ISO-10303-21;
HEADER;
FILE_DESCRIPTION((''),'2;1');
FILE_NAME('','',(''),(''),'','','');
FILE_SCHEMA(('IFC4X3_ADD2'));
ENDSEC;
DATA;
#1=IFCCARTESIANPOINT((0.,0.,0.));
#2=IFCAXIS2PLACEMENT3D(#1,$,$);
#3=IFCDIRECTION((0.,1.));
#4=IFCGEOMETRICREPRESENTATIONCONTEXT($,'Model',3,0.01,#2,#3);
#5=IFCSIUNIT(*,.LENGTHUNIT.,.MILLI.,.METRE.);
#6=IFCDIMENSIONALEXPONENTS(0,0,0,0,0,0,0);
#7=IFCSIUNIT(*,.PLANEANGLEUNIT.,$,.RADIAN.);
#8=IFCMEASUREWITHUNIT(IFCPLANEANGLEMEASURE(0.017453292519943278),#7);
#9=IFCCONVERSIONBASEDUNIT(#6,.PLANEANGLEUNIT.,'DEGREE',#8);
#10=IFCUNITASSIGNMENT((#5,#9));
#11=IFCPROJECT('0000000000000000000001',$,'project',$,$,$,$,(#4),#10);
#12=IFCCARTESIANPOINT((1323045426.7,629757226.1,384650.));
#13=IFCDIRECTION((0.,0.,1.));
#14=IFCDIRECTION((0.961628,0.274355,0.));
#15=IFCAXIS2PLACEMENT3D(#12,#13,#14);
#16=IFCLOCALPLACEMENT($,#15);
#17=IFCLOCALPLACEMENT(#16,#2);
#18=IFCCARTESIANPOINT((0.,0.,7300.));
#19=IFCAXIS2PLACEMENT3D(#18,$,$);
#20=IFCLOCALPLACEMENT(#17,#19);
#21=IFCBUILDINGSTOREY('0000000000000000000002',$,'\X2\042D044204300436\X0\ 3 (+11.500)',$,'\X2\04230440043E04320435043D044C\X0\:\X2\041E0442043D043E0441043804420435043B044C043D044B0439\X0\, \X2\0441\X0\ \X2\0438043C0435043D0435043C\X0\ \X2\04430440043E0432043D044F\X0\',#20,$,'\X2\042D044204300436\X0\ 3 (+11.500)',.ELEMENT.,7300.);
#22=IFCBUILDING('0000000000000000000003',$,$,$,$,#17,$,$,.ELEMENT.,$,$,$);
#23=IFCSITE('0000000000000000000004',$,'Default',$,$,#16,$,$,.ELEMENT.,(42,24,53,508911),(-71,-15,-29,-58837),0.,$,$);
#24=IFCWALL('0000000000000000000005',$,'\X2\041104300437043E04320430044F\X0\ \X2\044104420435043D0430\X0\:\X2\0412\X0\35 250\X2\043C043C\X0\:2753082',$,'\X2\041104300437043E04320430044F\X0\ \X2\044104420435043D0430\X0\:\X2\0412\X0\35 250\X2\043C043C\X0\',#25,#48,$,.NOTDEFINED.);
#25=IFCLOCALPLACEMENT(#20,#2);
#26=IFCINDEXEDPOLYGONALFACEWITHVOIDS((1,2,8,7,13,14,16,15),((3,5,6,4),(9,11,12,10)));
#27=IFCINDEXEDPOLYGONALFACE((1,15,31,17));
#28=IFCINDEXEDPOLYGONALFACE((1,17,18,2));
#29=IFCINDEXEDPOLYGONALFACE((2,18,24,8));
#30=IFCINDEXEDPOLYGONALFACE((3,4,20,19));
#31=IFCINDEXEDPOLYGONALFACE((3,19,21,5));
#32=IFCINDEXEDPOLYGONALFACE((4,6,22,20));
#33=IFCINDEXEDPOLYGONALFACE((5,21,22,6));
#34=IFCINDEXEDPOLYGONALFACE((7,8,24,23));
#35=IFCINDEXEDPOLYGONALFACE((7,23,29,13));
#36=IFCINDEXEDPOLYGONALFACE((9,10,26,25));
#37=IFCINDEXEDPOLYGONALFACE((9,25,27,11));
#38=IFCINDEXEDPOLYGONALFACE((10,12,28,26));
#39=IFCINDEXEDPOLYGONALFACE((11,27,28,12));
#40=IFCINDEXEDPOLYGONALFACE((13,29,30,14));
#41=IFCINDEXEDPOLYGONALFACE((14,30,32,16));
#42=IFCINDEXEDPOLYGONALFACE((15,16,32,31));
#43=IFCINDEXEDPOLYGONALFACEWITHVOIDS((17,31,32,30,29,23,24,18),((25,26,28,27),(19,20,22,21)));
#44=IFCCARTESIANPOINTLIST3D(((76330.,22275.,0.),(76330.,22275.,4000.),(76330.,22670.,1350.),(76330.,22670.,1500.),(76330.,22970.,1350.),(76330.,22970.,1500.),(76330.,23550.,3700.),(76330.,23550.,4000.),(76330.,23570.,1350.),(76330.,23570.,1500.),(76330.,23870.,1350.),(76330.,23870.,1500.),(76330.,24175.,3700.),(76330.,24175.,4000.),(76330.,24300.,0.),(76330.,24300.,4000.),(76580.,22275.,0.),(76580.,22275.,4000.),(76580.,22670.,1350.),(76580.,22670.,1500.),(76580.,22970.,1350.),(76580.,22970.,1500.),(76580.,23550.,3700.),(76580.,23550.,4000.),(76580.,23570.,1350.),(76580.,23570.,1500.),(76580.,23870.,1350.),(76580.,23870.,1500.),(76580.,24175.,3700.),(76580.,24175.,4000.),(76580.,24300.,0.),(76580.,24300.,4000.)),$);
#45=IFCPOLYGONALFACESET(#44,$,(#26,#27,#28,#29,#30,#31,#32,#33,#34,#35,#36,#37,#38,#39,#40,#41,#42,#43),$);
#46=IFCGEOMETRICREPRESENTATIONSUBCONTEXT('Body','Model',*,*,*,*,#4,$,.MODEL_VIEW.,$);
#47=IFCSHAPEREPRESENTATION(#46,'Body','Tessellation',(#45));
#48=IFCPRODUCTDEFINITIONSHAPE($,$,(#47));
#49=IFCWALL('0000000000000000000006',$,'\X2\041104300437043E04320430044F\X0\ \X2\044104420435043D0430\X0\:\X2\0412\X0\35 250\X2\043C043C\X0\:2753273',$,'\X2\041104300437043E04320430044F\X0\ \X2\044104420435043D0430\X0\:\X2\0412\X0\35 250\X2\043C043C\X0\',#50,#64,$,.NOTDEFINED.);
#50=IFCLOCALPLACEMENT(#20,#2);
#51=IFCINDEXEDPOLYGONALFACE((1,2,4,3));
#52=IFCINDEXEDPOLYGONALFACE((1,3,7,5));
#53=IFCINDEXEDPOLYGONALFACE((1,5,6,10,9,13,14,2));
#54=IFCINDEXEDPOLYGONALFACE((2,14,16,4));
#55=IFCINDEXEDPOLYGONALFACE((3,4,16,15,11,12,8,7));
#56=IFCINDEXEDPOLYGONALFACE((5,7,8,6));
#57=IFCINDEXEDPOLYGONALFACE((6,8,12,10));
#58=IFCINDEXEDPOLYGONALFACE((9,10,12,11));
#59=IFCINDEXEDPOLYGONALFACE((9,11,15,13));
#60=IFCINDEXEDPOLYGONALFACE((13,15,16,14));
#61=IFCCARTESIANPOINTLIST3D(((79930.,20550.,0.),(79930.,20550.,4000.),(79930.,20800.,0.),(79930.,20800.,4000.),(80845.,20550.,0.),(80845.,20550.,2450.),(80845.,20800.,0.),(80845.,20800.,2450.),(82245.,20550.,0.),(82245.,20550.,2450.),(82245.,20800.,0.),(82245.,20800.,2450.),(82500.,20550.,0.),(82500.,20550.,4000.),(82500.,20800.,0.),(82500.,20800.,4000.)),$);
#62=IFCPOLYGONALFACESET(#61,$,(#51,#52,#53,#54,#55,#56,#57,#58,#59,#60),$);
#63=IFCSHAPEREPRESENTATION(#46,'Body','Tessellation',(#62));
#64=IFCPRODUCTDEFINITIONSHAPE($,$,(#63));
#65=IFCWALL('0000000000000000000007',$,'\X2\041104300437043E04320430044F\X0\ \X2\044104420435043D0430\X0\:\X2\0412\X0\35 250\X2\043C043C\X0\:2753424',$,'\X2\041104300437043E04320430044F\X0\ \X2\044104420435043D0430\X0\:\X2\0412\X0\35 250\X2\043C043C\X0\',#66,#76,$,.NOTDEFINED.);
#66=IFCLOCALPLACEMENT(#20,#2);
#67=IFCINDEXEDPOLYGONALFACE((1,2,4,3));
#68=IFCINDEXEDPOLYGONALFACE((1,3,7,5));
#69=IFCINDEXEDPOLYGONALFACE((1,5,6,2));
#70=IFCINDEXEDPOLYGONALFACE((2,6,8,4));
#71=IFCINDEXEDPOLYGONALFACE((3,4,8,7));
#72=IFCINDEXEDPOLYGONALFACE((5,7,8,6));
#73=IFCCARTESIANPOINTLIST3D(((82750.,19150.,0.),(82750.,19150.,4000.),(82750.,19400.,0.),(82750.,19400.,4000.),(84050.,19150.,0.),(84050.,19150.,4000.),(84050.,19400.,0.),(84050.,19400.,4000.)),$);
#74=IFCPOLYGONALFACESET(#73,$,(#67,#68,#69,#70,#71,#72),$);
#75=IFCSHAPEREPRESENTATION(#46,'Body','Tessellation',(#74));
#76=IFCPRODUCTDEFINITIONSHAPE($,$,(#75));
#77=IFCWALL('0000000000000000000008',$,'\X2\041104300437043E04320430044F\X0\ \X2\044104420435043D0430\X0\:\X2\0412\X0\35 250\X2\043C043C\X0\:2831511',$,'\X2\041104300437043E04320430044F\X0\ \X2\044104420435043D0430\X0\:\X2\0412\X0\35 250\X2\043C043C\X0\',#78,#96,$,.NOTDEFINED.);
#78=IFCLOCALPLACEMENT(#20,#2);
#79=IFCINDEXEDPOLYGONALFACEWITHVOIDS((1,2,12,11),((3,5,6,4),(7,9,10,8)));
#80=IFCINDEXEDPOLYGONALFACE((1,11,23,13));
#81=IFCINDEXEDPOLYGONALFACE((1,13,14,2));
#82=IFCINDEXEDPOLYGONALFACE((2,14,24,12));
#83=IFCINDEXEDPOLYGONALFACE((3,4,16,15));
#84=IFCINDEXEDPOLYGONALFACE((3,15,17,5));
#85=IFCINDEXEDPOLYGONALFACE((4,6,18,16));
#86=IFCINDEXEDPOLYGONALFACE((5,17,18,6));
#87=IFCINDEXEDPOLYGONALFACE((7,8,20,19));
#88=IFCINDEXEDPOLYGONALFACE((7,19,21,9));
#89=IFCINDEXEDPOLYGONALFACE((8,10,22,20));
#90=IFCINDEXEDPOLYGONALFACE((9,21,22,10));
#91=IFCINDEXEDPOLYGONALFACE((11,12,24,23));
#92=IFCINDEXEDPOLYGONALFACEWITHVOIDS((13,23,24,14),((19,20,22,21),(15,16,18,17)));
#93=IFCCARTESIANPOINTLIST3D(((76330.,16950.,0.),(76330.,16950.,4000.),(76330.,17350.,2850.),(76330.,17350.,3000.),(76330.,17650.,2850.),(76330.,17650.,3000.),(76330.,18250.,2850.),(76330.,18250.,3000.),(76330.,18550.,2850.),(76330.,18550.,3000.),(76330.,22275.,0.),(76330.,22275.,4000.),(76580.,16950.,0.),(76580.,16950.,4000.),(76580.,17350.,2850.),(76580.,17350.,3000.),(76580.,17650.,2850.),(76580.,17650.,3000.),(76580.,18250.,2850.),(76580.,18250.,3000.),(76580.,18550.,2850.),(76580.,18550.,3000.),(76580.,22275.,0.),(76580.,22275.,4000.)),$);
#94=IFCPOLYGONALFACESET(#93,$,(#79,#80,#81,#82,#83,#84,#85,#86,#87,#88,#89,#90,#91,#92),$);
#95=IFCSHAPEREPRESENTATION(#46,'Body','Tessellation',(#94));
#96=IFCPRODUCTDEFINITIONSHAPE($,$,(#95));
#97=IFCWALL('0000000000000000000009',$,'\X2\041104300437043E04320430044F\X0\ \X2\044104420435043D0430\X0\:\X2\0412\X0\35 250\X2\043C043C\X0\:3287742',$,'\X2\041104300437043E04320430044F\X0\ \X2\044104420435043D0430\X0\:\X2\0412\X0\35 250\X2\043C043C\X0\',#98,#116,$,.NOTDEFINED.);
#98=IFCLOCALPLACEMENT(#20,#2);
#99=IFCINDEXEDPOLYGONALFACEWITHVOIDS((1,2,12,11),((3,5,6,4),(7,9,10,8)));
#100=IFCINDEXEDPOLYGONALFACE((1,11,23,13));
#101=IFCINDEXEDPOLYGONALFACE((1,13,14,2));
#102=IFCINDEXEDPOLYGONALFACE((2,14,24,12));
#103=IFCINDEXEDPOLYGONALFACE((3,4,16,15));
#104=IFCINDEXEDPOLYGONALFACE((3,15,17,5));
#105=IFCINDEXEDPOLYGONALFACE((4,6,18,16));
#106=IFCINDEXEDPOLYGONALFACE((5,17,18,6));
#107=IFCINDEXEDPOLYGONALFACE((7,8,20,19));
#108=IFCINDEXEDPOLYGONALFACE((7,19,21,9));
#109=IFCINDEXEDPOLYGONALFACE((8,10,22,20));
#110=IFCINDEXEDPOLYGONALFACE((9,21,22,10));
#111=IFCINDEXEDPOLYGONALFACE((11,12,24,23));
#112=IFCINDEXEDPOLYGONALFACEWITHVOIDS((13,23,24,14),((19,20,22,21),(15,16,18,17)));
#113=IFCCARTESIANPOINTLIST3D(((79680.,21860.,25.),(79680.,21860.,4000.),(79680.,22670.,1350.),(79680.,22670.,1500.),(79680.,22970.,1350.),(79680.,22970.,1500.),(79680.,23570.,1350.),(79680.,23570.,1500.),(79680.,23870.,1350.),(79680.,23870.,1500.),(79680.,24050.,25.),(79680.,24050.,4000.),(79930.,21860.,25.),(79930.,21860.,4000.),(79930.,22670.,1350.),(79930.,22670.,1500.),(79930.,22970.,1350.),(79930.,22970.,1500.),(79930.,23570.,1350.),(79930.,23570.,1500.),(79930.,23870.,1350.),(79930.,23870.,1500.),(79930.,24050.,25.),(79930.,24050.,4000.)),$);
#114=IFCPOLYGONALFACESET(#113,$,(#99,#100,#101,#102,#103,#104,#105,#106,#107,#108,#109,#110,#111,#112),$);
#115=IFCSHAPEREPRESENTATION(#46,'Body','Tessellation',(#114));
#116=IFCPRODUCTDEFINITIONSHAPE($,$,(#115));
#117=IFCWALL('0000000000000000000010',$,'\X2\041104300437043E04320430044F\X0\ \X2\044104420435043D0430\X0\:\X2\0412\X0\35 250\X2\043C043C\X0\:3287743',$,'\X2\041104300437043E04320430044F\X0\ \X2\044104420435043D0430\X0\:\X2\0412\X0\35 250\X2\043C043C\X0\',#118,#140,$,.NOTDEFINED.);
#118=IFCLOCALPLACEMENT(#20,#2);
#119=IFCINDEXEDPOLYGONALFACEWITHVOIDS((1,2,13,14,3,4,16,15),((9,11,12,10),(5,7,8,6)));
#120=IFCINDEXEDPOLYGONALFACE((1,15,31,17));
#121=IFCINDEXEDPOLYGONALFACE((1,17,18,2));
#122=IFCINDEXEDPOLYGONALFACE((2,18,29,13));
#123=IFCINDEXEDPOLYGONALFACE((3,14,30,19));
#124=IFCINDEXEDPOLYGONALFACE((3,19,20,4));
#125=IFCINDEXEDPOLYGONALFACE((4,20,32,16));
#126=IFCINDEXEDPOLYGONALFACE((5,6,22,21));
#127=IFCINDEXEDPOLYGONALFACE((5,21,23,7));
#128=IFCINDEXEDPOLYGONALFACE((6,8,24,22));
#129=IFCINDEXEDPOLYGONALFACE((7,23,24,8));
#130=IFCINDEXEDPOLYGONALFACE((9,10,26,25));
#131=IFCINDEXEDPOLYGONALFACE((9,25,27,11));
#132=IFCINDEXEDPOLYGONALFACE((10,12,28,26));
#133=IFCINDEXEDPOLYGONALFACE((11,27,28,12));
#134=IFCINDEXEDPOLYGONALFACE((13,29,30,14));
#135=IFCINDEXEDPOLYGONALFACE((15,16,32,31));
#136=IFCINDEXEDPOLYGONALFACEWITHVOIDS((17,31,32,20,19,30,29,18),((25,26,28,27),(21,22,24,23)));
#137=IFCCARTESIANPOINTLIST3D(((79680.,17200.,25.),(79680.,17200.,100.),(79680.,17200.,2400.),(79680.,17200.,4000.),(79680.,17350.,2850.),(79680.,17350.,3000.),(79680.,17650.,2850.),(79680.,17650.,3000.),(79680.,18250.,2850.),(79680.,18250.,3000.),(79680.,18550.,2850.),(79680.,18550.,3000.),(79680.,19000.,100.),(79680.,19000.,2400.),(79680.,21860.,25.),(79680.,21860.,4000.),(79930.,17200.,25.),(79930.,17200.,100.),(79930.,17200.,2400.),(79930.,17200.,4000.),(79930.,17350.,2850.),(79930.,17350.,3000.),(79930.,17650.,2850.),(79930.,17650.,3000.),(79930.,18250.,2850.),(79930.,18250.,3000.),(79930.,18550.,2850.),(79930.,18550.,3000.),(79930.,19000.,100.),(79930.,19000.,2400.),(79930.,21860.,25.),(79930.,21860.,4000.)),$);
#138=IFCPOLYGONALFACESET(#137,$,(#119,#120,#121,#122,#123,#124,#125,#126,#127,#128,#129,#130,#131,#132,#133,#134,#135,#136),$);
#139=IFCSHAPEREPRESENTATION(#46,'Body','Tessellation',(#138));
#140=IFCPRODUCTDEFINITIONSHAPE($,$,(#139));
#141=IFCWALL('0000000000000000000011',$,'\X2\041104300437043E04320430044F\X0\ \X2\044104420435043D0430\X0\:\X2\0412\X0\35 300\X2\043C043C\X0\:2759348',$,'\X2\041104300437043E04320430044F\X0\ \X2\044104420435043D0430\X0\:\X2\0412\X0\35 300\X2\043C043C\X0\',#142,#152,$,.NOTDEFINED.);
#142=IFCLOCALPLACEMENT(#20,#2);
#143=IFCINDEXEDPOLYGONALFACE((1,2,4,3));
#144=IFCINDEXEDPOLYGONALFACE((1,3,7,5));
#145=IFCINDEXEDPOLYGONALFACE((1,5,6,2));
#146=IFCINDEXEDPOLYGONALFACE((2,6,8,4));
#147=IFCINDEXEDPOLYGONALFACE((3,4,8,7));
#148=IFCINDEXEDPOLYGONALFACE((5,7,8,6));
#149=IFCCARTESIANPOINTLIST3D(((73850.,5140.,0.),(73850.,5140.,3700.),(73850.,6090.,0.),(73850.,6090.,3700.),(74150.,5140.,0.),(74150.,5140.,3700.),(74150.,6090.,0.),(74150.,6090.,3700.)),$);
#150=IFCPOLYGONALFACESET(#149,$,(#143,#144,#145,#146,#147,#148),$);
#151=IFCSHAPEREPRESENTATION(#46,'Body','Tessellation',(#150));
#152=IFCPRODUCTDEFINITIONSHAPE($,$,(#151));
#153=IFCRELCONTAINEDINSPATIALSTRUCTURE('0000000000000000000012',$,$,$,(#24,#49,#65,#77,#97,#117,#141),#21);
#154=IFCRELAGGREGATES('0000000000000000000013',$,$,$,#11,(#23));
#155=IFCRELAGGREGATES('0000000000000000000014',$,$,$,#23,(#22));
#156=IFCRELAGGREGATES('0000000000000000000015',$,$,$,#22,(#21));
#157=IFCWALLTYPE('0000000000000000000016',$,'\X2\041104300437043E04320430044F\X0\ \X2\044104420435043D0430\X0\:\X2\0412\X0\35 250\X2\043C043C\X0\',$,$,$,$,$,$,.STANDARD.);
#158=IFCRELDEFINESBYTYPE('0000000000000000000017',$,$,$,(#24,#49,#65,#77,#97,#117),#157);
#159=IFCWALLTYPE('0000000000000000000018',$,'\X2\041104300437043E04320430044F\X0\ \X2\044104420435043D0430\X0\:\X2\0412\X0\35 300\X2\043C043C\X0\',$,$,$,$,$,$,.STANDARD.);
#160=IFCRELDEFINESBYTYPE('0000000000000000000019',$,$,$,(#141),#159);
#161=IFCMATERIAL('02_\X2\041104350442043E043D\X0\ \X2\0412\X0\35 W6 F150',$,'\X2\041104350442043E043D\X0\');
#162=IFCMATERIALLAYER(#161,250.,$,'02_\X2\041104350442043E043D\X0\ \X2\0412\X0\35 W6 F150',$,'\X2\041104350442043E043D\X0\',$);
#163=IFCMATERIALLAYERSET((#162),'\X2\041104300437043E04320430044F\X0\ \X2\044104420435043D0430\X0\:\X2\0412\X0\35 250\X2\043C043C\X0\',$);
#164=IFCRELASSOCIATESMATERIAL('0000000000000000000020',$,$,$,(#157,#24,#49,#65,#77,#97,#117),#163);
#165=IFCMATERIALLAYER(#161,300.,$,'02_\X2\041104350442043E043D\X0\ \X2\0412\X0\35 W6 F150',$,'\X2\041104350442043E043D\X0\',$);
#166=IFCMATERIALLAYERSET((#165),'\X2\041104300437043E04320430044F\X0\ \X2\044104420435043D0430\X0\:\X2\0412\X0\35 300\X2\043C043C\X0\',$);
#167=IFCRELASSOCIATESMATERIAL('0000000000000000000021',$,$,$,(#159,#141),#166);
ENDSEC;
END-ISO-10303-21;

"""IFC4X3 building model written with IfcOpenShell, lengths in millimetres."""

from ifc_helpers import new_model, entity, si_unit, converted_unit, direction, frame, frame_2d, origin, place, context, subcontext, project, spatial, rectangle, extrude, material, layer, layer_set, type_object, element, save


model = new_model("IFC4X3")

# Units and contexts
model_context = context("Model", 3, precision=0.01, world=origin(), true_north=direction((0.0, 1.0)))
body_context = subcontext(model_context, "Body", "Model", "MODEL_VIEW")
ifc_project = project(units=[si_unit("LENGTHUNIT", "METRE", prefix="MILLI"), converted_unit("PLANEANGLEUNIT", "DEGREE", entity("IfcPlaneAngleMeasure", 0.017453292519943278), si_unit("PLANEANGLEUNIT", "RADIAN"), dimensions=[0, 0, 0, 0, 0, 0, 0])], contexts=[model_context])

# Site, building, storey
site_placement = place(None, frame((1323045426.7, 629757226.1, 384650.0), z_axis=(0.0, 0.0, 1.0), x_axis=(0.961628, 0.274355, 0.0)))
site = spatial("IfcSite", under=ifc_project, at=site_placement, Name="Default", CompositionType="ELEMENT", RefLatitude=(42, 24, 53, 508911), RefLongitude=(-71, -15, -29, -58837), RefElevation=0.0)
building_placement = place(site_placement, origin())
building = spatial("IfcBuilding", under=site, at=building_placement, CompositionType="ELEMENT")
storey_placement = place(building_placement, frame((0.0, 0.0, 7300.0)))
storey = spatial("IfcBuildingStorey", under=building, at=storey_placement, Name="Этаж 3 (+11.500)", ObjectType="Уровень:Относительный, с именем уровня", LongName="Этаж 3 (+11.500)", CompositionType="ELEMENT", Elevation=7300.0)

# Wall, openings
ifc_material = material(Name="02_Бетон В35 W6 F150", Category="Бетон")
ifc_layer_1 = layer(ifc_material, 250.0, Name="02_Бетон В35 W6 F150", Category="Бетон")
ifc_layer_set_1 = layer_set([ifc_layer_1], Name="Базовая стена:В35 250мм")
wall_type_1 = type_object("IfcWallType", Name="Базовая стена:В35 250мм", PredefinedType="STANDARD", material=ifc_layer_set_1)
wall_1_placement = place(storey_placement, frame((76455.0, 24300.0, 0.0), z_axis=(0.0, 0.0, 1.0), x_axis=(0.0, -1.0, 0.0)))
wall_1 = element("IfcWall", 1, at=wall_1_placement, inside=storey, type_object=wall_type_1, material=ifc_layer_set_1, Name="Базовая стена:В35 250мм:2753082", ObjectType="Базовая стена:В35 250мм", PredefinedType="NOTDEFINED", context=body_context, shape_type="SweptSolid", body=[
    extrude(rectangle(XDim=2025.0, YDim=250.0, at=frame_2d((1012.5, 0.0), x_axis=(-1.0, 0.0))), origin(), (0.0, 0.0, 1.0), 4000.0),
])
opening_1_placement = place(wall_1_placement, origin())
element("IfcOpeningElement", 2, at=opening_1_placement, cuts=wall_1, PredefinedType="OPENING", context=body_context, shape_type="SweptSolid", body=[
    extrude(rectangle(XDim=300.0, YDim=625.0, at=frame_2d((0.0, 0.0), x_axis=(0.0, 1.0))), frame((437.5, 125.0, 3850.0), z_axis=(0.0, -1.0, 0.0), x_axis=(-1.0, 0.0, 0.0)), (0.0, 0.0, 1.0), 250.0),
])
opening_2_placement = place(wall_1_placement, frame((24300.0, -76455.0, 1350.0), z_axis=(0.0, 0.0, 1.0), x_axis=(0.0, 1.0, 0.0)))
element("IfcOpeningElement", 3, at=opening_2_placement, cuts=wall_1, PredefinedType="OPENING", context=body_context, shape_type="SweptSolid", body=[
    extrude(rectangle(XDim=150.0, YDim=300.0, at=frame_2d((0.0, 0.0), x_axis=(0.0, 1.0))), frame((74806.0, 22820.0, 75.0), z_axis=(1.0, 0.0, 0.0), x_axis=(0.0, -1.0, 0.0)), (0.0, 0.0, 1.0), 3048.0),
])
opening_3_placement = place(wall_1_placement, frame((24300.0, -76455.0, 1350.0), z_axis=(0.0, 0.0, 1.0), x_axis=(0.0, 1.0, 0.0)))
element("IfcOpeningElement", 4, at=opening_3_placement, cuts=wall_1, PredefinedType="OPENING", context=body_context, shape_type="SweptSolid", body=[
    extrude(rectangle(XDim=150.0, YDim=300.0, at=frame_2d((0.0, 0.0), x_axis=(0.0, 1.0))), frame((74806.0, 23720.0, 75.0), z_axis=(1.0, 0.0, 0.0), x_axis=(0.0, -1.0, 0.0)), (0.0, 0.0, 1.0), 3048.0),
])

# Wall, opening
wall_2_placement = place(storey_placement, frame((79930.0, 20675.0, 0.0)))
wall_2 = element("IfcWall", 5, at=wall_2_placement, inside=storey, type_object=wall_type_1, material=ifc_layer_set_1, Name="Базовая стена:В35 250мм:2753273", ObjectType="Базовая стена:В35 250мм", PredefinedType="NOTDEFINED", context=body_context, shape_type="SweptSolid", body=[
    extrude(rectangle(XDim=2570.0, YDim=250.0, at=frame_2d((1285.0, 0.0), x_axis=(-1.0, 0.0))), origin(), (0.0, 0.0, 1.0), 4000.0),
])
opening_4_placement = place(wall_2_placement, frame((-79930.0, -20675.0, 0.0)))
element("IfcOpeningElement", 6, at=opening_4_placement, cuts=wall_2, PredefinedType="OPENING", context=body_context, shape_type="SweptSolid", body=[
    extrude(rectangle(XDim=2450.0, YDim=1400.0, at=frame_2d((0.0, 0.0), x_axis=(0.0, 1.0))), frame((81545.0, 19276.0, 1225.0), z_axis=(0.0, 1.0, 0.0), x_axis=(1.0, 0.0, 0.0)), (0.0, 0.0, 1.0), 3048.0),
])

# Wall
wall_3_placement = place(storey_placement, frame((82750.0, 19275.0, 0.0)))
element("IfcWall", 7, at=wall_3_placement, inside=storey, type_object=wall_type_1, material=ifc_layer_set_1, Name="Базовая стена:В35 250мм:2753424", ObjectType="Базовая стена:В35 250мм", PredefinedType="NOTDEFINED", context=body_context, shape_type="SweptSolid", body=[
    extrude(rectangle(XDim=1300.0, YDim=250.0, at=frame_2d((650.0, 0.0), x_axis=(-1.0, 0.0))), origin(), (0.0, 0.0, 1.0), 4000.0),
])

# Walls, openings
wall_4_placement = place(storey_placement, frame((76455.0, 22275.0, 0.0), z_axis=(0.0, 0.0, 1.0), x_axis=(0.0, -1.0, 0.0)))
wall_4 = element("IfcWall", 8, at=wall_4_placement, inside=storey, type_object=wall_type_1, material=ifc_layer_set_1, Name="Базовая стена:В35 250мм:2831511", ObjectType="Базовая стена:В35 250мм", PredefinedType="NOTDEFINED", context=body_context, shape_type="SweptSolid", body=[
    extrude(rectangle(XDim=5325.0, YDim=250.0, at=frame_2d((2662.5, 0.0), x_axis=(-1.0, 0.0))), origin(), (0.0, 0.0, 1.0), 4000.0),
])
opening_5_placement = place(wall_4_placement, frame((22275.0, -76455.0, 2850.0), z_axis=(0.0, 0.0, 1.0), x_axis=(0.0, 1.0, 0.0)))
element("IfcOpeningElement", 9, at=opening_5_placement, cuts=wall_4, PredefinedType="OPENING", context=body_context, shape_type="SweptSolid", body=[
    extrude(rectangle(XDim=150.0, YDim=300.0, at=frame_2d((0.0, 0.0), x_axis=(0.0, 1.0))), frame((74806.0, 17500.0, 75.0), z_axis=(1.0, 0.0, 0.0), x_axis=(0.0, -1.0, 0.0)), (0.0, 0.0, 1.0), 3048.0),
])
opening_6_placement = place(wall_4_placement, frame((22275.0, -76455.0, 2850.0), z_axis=(0.0, 0.0, 1.0), x_axis=(0.0, 1.0, 0.0)))
element("IfcOpeningElement", 10, at=opening_6_placement, cuts=wall_4, PredefinedType="OPENING", context=body_context, shape_type="SweptSolid", body=[
    extrude(rectangle(XDim=150.0, YDim=300.0, at=frame_2d((0.0, 0.0), x_axis=(0.0, 1.0))), frame((74806.0, 18400.0, 75.0), z_axis=(1.0, 0.0, 0.0), x_axis=(0.0, -1.0, 0.0)), (0.0, 0.0, 1.0), 3048.0),
])
wall_5_placement = place(storey_placement, frame((79805.0, 24050.0, 25.0), z_axis=(0.0, 0.0, 1.0), x_axis=(0.0, -1.0, 0.0)))
wall_5 = element("IfcWall", 11, at=wall_5_placement, inside=storey, type_object=wall_type_1, material=ifc_layer_set_1, Name="Базовая стена:В35 250мм:3287742", ObjectType="Базовая стена:В35 250мм", PredefinedType="NOTDEFINED", context=body_context, shape_type="SweptSolid", body=[
    extrude(rectangle(XDim=2190.0, YDim=250.0, at=frame_2d((1095.0, 0.0), x_axis=(-1.0, 0.0))), origin(), (0.0, 0.0, 1.0), 3975.0),
])
opening_7_placement = place(wall_5_placement, frame((24050.0, -79805.0, 1325.0), z_axis=(0.0, 0.0, 1.0), x_axis=(0.0, 1.0, 0.0)))
element("IfcOpeningElement", 12, at=opening_7_placement, cuts=wall_5, PredefinedType="OPENING", context=body_context, shape_type="SweptSolid", body=[
    extrude(rectangle(XDim=150.0, YDim=300.0, at=frame_2d((0.0, 0.0), x_axis=(0.0, 1.0))), frame((78156.0, 22820.0, 75.0), z_axis=(1.0, 0.0, 0.0), x_axis=(0.0, -1.0, 0.0)), (0.0, 0.0, 1.0), 3048.0),
])
opening_8_placement = place(wall_5_placement, frame((24050.0, -79805.0, 1325.0), z_axis=(0.0, 0.0, 1.0), x_axis=(0.0, 1.0, 0.0)))
element("IfcOpeningElement", 13, at=opening_8_placement, cuts=wall_5, PredefinedType="OPENING", context=body_context, shape_type="SweptSolid", body=[
    extrude(rectangle(XDim=150.0, YDim=300.0, at=frame_2d((0.0, 0.0), x_axis=(0.0, 1.0))), frame((78156.0, 23720.0, 75.0), z_axis=(1.0, 0.0, 0.0), x_axis=(0.0, -1.0, 0.0)), (0.0, 0.0, 1.0), 3048.0),
])
wall_6_placement = place(storey_placement, frame((79805.0, 21860.0, 25.0), z_axis=(0.0, 0.0, 1.0), x_axis=(0.0, -1.0, 0.0)))
wall_6 = element("IfcWall", 14, at=wall_6_placement, inside=storey, type_object=wall_type_1, material=ifc_layer_set_1, Name="Базовая стена:В35 250мм:3287743", ObjectType="Базовая стена:В35 250мм", PredefinedType="NOTDEFINED", context=body_context, shape_type="SweptSolid", body=[
    extrude(rectangle(XDim=4660.0, YDim=250.0, at=frame_2d((2330.0, 0.0), x_axis=(-1.0, 0.0))), origin(), (0.0, 0.0, 1.0), 3975.0),
])
opening_9_placement = place(wall_6_placement, frame((21860.0, -79805.0, 75.0), z_axis=(0.0, 0.0, 1.0), x_axis=(0.0, 1.0, 0.0)))
element("IfcOpeningElement", 15, at=opening_9_placement, cuts=wall_6, PredefinedType="OPENING", context=body_context, shape_type="SweptSolid", body=[
    extrude(rectangle(XDim=2300.0, YDim=1800.0, at=frame_2d((0.0, 0.0), x_axis=(1.0, 0.0))), frame((78156.0, 18100.0, 1150.0), z_axis=(1.0, 0.0, 0.0), x_axis=(0.0, 0.0, -1.0)), (0.0, 0.0, 1.0), 3048.0),
])
opening_10_placement = place(wall_6_placement, frame((21860.0, -79805.0, 2825.0), z_axis=(0.0, 0.0, 1.0), x_axis=(0.0, 1.0, 0.0)))
element("IfcOpeningElement", 16, at=opening_10_placement, cuts=wall_6, PredefinedType="OPENING", context=body_context, shape_type="SweptSolid", body=[
    extrude(rectangle(XDim=150.0, YDim=300.0, at=frame_2d((0.0, 0.0), x_axis=(0.0, 1.0))), frame((78156.0, 17500.0, 75.0), z_axis=(1.0, 0.0, 0.0), x_axis=(0.0, -1.0, 0.0)), (0.0, 0.0, 1.0), 3048.0),
])
opening_11_placement = place(wall_6_placement, frame((21860.0, -79805.0, 2825.0), z_axis=(0.0, 0.0, 1.0), x_axis=(0.0, 1.0, 0.0)))
element("IfcOpeningElement", 17, at=opening_11_placement, cuts=wall_6, PredefinedType="OPENING", context=body_context, shape_type="SweptSolid", body=[
    extrude(rectangle(XDim=150.0, YDim=300.0, at=frame_2d((0.0, 0.0), x_axis=(0.0, 1.0))), frame((78156.0, 18400.0, 75.0), z_axis=(1.0, 0.0, 0.0), x_axis=(0.0, -1.0, 0.0)), (0.0, 0.0, 1.0), 3048.0),
])

# Wall
ifc_layer_2 = layer(ifc_material, 300.0, Name="02_Бетон В35 W6 F150", Category="Бетон")
ifc_layer_set_2 = layer_set([ifc_layer_2], Name="Базовая стена:В35 300мм")
wall_type_2 = type_object("IfcWallType", Name="Базовая стена:В35 300мм", PredefinedType="STANDARD", material=ifc_layer_set_2)
for number, where, z_axis, x_axis, name in (
    (18, (74000.0, 5140.0, 0.0), (0.0, 0.0, 1.0), (0.0, 1.0, 0.0), "Базовая стена:В35 300мм:2759348"),
):
    element("IfcWall", number, at=place(storey_placement, frame(where, z_axis=z_axis, x_axis=x_axis)), inside=storey, type_object=wall_type_2, material=ifc_layer_set_2, Name=name, ObjectType="Базовая стена:В35 300мм", PredefinedType="NOTDEFINED", context=body_context, shape_type="SweptSolid", body=[
        extrude(rectangle(XDim=950.0, YDim=300.0, at=frame_2d((475.0, 0.0), x_axis=(-1.0, 0.0))), origin(), (0.0, 0.0, 1.0), 3700.0),
    ])

save(model, "model.ifc")
